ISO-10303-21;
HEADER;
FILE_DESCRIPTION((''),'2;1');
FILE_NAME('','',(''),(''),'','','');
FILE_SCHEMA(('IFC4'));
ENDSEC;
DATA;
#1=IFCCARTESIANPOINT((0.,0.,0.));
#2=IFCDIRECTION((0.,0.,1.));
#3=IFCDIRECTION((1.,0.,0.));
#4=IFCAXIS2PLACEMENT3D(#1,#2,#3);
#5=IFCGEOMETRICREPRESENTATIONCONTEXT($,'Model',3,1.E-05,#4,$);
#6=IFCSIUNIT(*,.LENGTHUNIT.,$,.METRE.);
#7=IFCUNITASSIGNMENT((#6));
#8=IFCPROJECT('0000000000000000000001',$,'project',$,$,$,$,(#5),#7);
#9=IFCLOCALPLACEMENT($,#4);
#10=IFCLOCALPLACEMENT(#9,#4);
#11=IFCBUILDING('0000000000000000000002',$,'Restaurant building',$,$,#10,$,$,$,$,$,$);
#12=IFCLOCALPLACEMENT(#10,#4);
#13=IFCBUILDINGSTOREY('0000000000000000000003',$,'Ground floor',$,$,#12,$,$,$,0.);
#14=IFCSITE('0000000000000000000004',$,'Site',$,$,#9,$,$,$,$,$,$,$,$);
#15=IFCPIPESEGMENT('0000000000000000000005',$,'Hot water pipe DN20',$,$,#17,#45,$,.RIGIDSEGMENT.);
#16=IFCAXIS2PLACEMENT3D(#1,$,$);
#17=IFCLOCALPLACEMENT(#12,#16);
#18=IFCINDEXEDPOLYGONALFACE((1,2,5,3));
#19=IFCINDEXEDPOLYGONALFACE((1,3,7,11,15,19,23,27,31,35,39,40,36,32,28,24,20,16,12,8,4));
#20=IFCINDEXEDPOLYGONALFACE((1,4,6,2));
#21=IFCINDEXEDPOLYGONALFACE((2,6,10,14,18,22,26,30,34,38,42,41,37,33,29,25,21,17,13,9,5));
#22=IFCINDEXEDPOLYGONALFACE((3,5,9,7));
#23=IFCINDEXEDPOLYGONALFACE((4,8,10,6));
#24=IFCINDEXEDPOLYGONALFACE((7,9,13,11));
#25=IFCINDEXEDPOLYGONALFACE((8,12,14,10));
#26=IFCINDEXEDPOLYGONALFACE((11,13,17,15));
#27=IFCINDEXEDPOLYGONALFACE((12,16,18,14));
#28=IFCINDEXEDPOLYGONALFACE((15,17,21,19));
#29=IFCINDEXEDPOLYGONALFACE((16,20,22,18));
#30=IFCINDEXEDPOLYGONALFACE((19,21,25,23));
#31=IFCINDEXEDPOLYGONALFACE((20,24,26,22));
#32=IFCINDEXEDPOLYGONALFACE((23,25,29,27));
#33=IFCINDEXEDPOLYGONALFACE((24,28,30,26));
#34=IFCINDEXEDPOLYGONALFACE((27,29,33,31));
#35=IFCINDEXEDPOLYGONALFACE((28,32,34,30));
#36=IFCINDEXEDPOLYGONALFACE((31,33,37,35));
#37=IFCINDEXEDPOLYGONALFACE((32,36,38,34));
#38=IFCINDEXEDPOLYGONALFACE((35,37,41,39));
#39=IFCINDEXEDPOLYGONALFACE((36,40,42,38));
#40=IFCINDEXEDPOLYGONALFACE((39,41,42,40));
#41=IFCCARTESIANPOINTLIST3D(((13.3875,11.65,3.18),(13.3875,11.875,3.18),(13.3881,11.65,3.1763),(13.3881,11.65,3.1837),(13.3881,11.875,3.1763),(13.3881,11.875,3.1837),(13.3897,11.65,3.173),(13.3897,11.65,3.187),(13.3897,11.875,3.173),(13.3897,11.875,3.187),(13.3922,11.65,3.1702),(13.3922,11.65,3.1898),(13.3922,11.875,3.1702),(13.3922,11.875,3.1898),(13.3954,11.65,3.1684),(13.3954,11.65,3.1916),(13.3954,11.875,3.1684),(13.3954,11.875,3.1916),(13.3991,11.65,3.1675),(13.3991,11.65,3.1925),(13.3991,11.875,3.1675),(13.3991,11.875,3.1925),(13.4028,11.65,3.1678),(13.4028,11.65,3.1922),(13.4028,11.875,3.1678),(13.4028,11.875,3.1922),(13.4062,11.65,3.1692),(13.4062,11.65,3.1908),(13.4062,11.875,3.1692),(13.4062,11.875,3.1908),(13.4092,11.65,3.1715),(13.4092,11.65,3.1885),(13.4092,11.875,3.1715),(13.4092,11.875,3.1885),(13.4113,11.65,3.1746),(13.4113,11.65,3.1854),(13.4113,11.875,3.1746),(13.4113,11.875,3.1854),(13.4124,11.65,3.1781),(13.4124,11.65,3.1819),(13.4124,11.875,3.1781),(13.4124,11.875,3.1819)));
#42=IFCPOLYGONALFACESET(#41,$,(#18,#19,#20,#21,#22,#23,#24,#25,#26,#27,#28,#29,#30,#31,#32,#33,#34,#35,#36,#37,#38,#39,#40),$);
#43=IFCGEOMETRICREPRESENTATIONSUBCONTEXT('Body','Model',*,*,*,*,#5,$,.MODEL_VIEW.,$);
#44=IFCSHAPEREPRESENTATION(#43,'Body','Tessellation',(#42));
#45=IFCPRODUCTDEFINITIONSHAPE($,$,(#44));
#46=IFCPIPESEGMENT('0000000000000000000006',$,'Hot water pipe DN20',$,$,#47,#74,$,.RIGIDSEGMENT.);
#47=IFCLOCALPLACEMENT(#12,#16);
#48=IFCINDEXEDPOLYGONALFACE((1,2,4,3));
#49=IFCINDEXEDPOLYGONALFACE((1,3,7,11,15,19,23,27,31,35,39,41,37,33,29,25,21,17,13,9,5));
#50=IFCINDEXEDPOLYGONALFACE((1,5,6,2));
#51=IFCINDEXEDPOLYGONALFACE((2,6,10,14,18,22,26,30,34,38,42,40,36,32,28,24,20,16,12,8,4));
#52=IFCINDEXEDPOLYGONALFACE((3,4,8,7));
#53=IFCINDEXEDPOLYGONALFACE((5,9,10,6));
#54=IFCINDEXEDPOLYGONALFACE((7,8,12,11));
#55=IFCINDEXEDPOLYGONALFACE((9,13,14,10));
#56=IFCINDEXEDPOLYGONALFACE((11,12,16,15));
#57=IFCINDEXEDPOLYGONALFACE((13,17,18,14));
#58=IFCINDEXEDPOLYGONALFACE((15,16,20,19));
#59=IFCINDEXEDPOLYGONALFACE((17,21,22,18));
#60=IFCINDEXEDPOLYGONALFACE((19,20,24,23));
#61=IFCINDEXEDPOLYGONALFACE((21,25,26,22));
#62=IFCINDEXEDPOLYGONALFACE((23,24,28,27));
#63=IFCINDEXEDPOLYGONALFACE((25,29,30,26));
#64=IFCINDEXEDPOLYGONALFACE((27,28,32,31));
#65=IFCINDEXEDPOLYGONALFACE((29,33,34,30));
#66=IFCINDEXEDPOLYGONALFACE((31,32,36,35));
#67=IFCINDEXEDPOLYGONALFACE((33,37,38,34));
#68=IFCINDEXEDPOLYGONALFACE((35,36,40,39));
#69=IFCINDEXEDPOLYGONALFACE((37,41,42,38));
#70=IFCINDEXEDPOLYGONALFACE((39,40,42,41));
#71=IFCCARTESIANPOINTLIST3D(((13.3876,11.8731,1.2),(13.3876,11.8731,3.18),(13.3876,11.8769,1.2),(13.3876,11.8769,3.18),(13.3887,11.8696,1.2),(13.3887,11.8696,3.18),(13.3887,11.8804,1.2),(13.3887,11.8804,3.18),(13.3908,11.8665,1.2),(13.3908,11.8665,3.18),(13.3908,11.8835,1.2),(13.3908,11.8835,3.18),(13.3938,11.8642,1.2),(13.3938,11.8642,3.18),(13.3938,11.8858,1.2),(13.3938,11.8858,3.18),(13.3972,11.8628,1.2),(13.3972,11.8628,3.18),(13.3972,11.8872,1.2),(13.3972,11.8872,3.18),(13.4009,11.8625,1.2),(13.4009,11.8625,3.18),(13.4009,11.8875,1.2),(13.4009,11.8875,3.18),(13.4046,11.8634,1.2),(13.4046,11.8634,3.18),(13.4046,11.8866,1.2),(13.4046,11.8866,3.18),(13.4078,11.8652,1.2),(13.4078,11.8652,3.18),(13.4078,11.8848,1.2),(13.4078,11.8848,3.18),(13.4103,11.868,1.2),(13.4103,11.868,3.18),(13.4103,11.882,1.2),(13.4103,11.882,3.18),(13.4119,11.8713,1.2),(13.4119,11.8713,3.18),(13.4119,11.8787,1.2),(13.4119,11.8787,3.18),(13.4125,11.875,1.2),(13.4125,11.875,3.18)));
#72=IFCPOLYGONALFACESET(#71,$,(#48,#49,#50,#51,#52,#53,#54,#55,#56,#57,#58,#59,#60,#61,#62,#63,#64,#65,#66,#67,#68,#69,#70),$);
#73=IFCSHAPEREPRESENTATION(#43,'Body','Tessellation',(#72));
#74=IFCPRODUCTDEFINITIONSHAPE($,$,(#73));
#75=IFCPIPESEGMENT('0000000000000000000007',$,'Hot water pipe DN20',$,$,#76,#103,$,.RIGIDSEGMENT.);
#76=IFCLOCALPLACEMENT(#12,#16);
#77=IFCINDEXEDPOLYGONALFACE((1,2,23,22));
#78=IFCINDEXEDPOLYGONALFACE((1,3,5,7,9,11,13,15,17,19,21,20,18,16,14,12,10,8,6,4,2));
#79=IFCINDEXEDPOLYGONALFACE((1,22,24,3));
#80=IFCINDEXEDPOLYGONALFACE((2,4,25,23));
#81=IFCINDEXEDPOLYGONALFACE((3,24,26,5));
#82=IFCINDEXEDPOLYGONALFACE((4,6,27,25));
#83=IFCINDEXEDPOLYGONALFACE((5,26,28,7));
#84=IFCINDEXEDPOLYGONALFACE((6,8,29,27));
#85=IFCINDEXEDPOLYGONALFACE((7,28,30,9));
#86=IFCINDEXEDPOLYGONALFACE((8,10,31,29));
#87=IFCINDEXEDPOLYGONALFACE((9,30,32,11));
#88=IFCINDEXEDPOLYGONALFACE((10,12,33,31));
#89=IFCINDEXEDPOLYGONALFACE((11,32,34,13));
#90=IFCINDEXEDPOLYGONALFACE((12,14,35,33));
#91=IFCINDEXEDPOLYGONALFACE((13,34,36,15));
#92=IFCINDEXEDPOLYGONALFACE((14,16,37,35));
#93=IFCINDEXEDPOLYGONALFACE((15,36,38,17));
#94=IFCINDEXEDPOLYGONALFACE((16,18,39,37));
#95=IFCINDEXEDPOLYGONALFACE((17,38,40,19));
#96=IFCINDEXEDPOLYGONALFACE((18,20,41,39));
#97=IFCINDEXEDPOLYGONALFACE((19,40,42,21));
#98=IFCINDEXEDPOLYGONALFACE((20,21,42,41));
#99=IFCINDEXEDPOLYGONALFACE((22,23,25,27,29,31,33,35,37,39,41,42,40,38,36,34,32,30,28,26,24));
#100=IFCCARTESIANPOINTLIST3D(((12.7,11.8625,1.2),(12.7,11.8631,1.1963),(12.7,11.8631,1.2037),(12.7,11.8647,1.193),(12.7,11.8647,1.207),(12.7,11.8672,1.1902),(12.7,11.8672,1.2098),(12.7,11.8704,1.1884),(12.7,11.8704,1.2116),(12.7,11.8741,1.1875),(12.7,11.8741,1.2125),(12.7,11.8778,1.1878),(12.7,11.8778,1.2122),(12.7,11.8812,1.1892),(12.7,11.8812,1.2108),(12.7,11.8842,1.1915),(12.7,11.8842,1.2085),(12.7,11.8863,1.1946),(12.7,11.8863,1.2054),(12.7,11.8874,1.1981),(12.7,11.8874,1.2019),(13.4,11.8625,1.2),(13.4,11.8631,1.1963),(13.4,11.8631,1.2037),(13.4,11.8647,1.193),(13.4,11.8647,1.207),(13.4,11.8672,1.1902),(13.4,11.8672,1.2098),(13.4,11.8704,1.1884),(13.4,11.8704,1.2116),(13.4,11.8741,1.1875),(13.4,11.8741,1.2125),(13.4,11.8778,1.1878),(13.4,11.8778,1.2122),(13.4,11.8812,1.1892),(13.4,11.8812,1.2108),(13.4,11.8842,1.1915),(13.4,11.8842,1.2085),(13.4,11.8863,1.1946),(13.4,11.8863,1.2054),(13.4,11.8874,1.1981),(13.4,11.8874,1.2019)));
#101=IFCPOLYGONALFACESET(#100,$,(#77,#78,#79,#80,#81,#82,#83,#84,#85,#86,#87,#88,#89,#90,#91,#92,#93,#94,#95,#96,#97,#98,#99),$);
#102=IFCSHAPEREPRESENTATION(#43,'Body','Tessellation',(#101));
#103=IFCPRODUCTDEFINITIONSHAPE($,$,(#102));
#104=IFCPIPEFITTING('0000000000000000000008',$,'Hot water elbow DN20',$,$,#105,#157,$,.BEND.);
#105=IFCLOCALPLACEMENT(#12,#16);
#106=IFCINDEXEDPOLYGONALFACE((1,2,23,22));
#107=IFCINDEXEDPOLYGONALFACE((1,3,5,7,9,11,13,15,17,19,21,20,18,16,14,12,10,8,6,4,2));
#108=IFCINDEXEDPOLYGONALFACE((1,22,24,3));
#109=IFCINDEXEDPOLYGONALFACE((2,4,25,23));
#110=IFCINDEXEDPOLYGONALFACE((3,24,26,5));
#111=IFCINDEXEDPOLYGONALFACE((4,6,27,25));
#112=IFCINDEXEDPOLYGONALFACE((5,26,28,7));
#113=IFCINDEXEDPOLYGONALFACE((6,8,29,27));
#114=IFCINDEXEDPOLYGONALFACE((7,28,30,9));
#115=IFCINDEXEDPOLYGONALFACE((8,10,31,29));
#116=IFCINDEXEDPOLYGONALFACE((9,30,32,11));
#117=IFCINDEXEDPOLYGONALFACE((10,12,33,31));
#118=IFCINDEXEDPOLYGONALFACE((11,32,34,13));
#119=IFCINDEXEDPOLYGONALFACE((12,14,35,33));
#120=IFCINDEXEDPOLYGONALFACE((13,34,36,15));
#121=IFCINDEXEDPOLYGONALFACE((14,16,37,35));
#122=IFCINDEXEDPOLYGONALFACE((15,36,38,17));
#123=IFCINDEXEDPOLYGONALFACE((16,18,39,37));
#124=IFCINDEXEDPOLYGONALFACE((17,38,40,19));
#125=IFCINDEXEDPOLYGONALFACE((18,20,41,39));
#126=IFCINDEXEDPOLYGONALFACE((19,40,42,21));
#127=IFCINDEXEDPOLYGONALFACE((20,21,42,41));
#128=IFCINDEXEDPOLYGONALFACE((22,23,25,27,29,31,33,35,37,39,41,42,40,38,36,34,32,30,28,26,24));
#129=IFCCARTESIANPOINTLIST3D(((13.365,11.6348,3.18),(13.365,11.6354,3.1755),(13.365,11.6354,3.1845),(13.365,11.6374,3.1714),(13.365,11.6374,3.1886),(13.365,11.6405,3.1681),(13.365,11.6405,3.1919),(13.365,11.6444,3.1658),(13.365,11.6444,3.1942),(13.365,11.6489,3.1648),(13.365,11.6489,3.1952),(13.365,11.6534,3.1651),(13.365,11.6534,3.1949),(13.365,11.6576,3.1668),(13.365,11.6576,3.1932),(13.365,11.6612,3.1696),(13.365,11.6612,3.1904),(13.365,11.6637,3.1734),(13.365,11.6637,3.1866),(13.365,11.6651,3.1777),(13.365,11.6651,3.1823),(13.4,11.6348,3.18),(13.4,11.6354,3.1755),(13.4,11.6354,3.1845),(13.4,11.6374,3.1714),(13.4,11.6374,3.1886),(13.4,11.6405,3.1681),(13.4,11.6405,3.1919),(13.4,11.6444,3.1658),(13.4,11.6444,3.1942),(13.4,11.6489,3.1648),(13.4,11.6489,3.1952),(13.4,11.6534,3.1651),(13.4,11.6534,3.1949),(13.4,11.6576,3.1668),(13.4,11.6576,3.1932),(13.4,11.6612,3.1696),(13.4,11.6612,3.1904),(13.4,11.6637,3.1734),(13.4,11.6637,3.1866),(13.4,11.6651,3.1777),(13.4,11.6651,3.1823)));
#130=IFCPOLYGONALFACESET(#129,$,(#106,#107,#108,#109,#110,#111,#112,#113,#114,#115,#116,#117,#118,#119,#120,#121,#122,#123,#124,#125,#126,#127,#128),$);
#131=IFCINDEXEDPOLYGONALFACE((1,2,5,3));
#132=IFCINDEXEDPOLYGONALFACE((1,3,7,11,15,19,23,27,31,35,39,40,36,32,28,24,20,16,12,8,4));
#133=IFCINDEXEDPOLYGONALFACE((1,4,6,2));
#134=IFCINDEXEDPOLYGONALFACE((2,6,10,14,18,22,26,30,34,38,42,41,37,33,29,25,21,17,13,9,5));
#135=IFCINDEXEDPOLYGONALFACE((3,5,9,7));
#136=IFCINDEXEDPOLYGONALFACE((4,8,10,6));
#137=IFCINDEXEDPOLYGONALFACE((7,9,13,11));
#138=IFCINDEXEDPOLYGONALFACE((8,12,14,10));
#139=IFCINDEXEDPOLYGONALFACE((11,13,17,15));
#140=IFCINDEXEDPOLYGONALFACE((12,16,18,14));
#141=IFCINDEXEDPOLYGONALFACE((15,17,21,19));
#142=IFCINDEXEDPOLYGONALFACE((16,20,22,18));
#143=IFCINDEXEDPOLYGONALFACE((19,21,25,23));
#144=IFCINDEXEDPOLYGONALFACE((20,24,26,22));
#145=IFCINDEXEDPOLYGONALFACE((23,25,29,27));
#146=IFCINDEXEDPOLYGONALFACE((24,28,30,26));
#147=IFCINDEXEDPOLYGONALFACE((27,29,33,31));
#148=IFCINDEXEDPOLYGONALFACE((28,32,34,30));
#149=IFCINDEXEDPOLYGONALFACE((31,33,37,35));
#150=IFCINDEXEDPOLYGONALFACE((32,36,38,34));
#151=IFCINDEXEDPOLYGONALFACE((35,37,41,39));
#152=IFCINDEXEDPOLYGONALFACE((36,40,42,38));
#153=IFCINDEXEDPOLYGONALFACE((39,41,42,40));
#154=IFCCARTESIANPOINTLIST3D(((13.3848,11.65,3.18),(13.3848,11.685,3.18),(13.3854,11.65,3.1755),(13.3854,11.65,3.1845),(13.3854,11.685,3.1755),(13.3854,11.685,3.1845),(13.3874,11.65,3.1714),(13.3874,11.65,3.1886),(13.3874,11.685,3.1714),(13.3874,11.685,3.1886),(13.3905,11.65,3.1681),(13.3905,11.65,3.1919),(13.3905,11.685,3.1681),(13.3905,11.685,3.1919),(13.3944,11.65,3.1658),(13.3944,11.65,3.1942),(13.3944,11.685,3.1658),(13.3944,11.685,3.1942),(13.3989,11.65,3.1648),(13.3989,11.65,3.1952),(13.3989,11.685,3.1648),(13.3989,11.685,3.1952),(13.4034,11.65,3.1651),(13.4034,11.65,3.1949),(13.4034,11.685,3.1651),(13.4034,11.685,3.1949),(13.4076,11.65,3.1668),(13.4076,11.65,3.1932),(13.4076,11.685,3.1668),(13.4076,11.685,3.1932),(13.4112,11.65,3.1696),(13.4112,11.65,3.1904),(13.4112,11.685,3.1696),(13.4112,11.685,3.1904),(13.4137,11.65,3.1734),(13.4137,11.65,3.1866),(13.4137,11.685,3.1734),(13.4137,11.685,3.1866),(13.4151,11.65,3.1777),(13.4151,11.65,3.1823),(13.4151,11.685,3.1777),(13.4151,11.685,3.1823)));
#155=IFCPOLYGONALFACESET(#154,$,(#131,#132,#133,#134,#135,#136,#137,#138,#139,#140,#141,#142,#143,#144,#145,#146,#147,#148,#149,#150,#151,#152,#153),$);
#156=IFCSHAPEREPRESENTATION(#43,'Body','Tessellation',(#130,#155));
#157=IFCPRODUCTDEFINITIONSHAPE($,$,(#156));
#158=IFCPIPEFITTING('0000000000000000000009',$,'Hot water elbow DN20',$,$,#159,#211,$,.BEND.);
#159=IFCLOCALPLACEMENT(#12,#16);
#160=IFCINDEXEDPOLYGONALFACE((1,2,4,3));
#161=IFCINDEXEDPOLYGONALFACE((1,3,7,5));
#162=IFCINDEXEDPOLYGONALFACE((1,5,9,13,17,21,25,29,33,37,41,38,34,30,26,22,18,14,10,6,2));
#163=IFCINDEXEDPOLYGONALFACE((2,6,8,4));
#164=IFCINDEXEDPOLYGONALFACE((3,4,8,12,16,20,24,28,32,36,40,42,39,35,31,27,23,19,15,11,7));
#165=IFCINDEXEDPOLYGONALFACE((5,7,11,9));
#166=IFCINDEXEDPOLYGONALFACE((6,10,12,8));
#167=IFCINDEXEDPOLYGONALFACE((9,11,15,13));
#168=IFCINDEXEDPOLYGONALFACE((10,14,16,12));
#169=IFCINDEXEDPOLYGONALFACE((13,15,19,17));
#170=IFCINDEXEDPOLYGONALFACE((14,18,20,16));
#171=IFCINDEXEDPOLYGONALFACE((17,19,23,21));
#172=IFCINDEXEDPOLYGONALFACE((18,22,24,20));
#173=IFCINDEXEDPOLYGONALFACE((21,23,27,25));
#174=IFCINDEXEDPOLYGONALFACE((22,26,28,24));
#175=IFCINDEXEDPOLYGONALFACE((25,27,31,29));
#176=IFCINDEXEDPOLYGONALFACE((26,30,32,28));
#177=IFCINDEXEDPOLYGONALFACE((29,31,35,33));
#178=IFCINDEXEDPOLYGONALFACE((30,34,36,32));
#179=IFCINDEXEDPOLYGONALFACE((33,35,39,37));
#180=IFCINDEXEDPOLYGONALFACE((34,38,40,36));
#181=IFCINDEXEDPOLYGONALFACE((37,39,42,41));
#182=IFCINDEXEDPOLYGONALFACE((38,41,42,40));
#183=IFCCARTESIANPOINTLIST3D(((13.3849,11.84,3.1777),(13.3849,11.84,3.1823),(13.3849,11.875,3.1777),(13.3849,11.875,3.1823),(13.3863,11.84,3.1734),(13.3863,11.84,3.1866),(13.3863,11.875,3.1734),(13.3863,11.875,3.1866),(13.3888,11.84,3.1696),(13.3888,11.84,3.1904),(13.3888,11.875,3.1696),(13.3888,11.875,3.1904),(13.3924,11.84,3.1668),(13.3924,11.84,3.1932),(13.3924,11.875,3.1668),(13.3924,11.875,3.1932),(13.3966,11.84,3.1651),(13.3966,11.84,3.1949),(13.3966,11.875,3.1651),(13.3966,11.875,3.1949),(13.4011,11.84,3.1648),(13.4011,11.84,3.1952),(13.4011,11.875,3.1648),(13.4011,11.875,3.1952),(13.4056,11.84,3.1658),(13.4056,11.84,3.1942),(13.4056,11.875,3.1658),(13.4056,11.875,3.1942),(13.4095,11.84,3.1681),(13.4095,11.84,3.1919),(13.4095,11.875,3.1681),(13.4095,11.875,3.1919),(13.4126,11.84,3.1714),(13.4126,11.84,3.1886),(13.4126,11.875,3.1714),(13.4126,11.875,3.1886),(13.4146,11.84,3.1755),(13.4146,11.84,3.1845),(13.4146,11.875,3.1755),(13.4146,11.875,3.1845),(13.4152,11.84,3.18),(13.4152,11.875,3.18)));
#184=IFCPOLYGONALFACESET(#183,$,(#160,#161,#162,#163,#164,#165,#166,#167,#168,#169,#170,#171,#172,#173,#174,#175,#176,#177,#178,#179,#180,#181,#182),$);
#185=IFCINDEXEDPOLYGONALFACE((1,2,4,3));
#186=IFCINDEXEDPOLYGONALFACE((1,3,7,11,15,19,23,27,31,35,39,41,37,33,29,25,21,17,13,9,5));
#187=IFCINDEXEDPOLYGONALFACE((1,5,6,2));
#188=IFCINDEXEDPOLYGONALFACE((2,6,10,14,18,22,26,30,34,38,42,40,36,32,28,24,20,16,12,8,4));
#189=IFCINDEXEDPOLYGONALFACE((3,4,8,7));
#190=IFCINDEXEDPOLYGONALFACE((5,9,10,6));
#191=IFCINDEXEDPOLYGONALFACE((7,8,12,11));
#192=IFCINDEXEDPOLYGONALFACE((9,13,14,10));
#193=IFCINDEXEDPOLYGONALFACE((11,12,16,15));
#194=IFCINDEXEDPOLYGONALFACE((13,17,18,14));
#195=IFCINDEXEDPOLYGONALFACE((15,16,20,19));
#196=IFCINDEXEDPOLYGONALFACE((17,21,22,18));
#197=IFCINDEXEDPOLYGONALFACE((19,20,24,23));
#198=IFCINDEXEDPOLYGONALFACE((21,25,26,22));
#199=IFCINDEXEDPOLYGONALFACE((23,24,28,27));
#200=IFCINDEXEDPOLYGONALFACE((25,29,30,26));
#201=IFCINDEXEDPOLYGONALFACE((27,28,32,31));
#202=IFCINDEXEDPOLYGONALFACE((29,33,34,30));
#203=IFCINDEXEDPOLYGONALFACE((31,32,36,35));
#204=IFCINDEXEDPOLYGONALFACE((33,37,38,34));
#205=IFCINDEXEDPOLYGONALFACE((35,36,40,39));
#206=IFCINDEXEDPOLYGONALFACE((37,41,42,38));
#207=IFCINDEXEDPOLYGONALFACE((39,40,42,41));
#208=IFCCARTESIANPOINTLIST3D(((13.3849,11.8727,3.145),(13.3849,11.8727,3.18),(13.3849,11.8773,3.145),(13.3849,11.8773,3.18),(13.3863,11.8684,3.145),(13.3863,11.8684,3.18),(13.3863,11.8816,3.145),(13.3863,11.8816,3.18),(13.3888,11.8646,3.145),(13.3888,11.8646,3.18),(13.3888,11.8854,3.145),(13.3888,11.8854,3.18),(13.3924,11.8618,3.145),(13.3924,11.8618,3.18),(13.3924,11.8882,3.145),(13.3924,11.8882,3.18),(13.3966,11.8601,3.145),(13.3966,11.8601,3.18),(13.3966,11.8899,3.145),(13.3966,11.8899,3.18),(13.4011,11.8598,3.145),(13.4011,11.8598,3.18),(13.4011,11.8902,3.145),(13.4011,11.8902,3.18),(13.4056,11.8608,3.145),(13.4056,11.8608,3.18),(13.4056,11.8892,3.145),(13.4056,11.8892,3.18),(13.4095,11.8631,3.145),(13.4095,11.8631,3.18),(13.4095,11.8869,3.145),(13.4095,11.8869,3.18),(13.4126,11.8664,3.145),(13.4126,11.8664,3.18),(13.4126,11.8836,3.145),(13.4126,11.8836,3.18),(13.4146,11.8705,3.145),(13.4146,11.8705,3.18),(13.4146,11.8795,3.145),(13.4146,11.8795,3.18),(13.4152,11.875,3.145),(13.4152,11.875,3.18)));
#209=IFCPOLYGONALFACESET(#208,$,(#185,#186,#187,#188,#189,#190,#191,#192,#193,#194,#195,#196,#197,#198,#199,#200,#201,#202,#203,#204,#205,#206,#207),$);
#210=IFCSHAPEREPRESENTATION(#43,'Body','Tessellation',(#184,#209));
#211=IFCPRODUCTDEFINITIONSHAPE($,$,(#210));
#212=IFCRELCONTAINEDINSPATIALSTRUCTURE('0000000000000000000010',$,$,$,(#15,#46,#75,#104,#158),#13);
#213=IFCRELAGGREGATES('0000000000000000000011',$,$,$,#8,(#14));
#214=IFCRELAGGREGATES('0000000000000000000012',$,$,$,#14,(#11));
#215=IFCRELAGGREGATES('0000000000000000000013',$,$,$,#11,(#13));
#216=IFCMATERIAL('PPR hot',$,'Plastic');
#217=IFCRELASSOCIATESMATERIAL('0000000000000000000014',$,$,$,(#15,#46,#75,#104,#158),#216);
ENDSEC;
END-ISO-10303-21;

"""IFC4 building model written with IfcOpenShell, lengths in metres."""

from ifc_helpers import new_model, si_unit, frame, origin_with_axes, origin_2d, place, context, subcontext, project, spatial, circle, extrude, material, element, save


model = new_model("IFC4")

# Units and contexts
model_context = context("Model", 3, precision=1e-05, world=origin_with_axes())
body_context = subcontext(model_context, "Body", "Model", "MODEL_VIEW")
ifc_project = project(units=[si_unit("LENGTHUNIT", "METRE")], contexts=[model_context])

# Site, building, storey
site_placement = place(None, origin_with_axes())
site = spatial("IfcSite", under=ifc_project, at=site_placement, Name="Site")
building_placement = place(site_placement, origin_with_axes())
building = spatial("IfcBuilding", under=site, at=building_placement, Name="Restaurant building")
storey_placement = place(building_placement, origin_with_axes())
storey = spatial("IfcBuildingStorey", under=building, at=storey_placement, Name="Ground floor", Elevation=0.0)

# Pipe segments
ifc_material_1 = material(Name="PPR hot", Category="Plastic")
pipe_segment_1_placement = place(storey_placement, frame((13.4, 11.65, 3.18)))
element("IfcPipeSegment", 1, at=pipe_segment_1_placement, inside=storey, material=ifc_material_1, Name="Hot water pipe DN20", PredefinedType="RIGIDSEGMENT", context=body_context, shape_type="SweptSolid", body=[
    extrude(circle(Radius=0.0125, at=origin_2d()), frame((0.0, 0.0, 0.0), z_axis=(0.0, 1.0, 0.0), x_axis=(-1.0, 0.0, 0.0)), (0.0, 0.0, 1.0), 0.225),
])
pipe_segment_2_placement = place(storey_placement, frame((13.4, 11.875, 3.18)))
element("IfcPipeSegment", 2, at=pipe_segment_2_placement, inside=storey, material=ifc_material_1, Name="Hot water pipe DN20", PredefinedType="RIGIDSEGMENT", context=body_context, shape_type="SweptSolid", body=[
    extrude(circle(Radius=0.0125, at=origin_2d()), frame((0.0, 0.0, 0.0), z_axis=(0.0, 0.0, -1.0), x_axis=(1.0, 0.0, 0.0)), (0.0, 0.0, 1.0), 1.98),
])
pipe_segment_3_placement = place(storey_placement, frame((13.4, 11.875, 1.2)))
element("IfcPipeSegment", 3, at=pipe_segment_3_placement, inside=storey, material=ifc_material_1, Name="Hot water pipe DN20", PredefinedType="RIGIDSEGMENT", context=body_context, shape_type="SweptSolid", body=[
    extrude(circle(Radius=0.0125, at=origin_2d()), frame((0.0, 0.0, 0.0), z_axis=(-1.0, 0.0, 0.0), x_axis=(0.0, -1.0, 0.0)), (0.0, 0.0, 1.0), 0.7),
])

# Pipe fittings
pipe_fitting_1_placement = place(storey_placement, frame((13.4, 11.65, 3.18)))
element("IfcPipeFitting", 4, at=pipe_fitting_1_placement, inside=storey, material=ifc_material_1, Name="Hot water elbow DN20", PredefinedType="BEND", context=body_context, shape_type="SweptSolid", body=[
    extrude(circle(Radius=0.0152, at=origin_2d()), frame((0.0, 0.0, 0.0), z_axis=(-1.0, 0.0, 0.0), x_axis=(0.0, -1.0, 0.0)), (0.0, 0.0, 1.0), 0.035),
    extrude(circle(Radius=0.0152, at=origin_2d()), frame((0.0, 0.0, 0.0), z_axis=(0.0, 1.0, 0.0), x_axis=(-1.0, 0.0, 0.0)), (0.0, 0.0, 1.0), 0.035),
])
pipe_fitting_2_placement = place(storey_placement, frame((13.4, 11.875, 3.18)))
element("IfcPipeFitting", 5, at=pipe_fitting_2_placement, inside=storey, material=ifc_material_1, Name="Hot water elbow DN20", PredefinedType="BEND", context=body_context, shape_type="SweptSolid", body=[
    extrude(circle(Radius=0.0152, at=origin_2d()), frame((0.0, 0.0, 0.0), z_axis=(0.0, -1.0, 0.0), x_axis=(1.0, 0.0, 0.0)), (0.0, 0.0, 1.0), 0.035),
    extrude(circle(Radius=0.0152, at=origin_2d()), frame((0.0, 0.0, 0.0), z_axis=(0.0, 0.0, -1.0), x_axis=(1.0, 0.0, 0.0)), (0.0, 0.0, 1.0), 0.035),
])

save(model, "model.ifc")
